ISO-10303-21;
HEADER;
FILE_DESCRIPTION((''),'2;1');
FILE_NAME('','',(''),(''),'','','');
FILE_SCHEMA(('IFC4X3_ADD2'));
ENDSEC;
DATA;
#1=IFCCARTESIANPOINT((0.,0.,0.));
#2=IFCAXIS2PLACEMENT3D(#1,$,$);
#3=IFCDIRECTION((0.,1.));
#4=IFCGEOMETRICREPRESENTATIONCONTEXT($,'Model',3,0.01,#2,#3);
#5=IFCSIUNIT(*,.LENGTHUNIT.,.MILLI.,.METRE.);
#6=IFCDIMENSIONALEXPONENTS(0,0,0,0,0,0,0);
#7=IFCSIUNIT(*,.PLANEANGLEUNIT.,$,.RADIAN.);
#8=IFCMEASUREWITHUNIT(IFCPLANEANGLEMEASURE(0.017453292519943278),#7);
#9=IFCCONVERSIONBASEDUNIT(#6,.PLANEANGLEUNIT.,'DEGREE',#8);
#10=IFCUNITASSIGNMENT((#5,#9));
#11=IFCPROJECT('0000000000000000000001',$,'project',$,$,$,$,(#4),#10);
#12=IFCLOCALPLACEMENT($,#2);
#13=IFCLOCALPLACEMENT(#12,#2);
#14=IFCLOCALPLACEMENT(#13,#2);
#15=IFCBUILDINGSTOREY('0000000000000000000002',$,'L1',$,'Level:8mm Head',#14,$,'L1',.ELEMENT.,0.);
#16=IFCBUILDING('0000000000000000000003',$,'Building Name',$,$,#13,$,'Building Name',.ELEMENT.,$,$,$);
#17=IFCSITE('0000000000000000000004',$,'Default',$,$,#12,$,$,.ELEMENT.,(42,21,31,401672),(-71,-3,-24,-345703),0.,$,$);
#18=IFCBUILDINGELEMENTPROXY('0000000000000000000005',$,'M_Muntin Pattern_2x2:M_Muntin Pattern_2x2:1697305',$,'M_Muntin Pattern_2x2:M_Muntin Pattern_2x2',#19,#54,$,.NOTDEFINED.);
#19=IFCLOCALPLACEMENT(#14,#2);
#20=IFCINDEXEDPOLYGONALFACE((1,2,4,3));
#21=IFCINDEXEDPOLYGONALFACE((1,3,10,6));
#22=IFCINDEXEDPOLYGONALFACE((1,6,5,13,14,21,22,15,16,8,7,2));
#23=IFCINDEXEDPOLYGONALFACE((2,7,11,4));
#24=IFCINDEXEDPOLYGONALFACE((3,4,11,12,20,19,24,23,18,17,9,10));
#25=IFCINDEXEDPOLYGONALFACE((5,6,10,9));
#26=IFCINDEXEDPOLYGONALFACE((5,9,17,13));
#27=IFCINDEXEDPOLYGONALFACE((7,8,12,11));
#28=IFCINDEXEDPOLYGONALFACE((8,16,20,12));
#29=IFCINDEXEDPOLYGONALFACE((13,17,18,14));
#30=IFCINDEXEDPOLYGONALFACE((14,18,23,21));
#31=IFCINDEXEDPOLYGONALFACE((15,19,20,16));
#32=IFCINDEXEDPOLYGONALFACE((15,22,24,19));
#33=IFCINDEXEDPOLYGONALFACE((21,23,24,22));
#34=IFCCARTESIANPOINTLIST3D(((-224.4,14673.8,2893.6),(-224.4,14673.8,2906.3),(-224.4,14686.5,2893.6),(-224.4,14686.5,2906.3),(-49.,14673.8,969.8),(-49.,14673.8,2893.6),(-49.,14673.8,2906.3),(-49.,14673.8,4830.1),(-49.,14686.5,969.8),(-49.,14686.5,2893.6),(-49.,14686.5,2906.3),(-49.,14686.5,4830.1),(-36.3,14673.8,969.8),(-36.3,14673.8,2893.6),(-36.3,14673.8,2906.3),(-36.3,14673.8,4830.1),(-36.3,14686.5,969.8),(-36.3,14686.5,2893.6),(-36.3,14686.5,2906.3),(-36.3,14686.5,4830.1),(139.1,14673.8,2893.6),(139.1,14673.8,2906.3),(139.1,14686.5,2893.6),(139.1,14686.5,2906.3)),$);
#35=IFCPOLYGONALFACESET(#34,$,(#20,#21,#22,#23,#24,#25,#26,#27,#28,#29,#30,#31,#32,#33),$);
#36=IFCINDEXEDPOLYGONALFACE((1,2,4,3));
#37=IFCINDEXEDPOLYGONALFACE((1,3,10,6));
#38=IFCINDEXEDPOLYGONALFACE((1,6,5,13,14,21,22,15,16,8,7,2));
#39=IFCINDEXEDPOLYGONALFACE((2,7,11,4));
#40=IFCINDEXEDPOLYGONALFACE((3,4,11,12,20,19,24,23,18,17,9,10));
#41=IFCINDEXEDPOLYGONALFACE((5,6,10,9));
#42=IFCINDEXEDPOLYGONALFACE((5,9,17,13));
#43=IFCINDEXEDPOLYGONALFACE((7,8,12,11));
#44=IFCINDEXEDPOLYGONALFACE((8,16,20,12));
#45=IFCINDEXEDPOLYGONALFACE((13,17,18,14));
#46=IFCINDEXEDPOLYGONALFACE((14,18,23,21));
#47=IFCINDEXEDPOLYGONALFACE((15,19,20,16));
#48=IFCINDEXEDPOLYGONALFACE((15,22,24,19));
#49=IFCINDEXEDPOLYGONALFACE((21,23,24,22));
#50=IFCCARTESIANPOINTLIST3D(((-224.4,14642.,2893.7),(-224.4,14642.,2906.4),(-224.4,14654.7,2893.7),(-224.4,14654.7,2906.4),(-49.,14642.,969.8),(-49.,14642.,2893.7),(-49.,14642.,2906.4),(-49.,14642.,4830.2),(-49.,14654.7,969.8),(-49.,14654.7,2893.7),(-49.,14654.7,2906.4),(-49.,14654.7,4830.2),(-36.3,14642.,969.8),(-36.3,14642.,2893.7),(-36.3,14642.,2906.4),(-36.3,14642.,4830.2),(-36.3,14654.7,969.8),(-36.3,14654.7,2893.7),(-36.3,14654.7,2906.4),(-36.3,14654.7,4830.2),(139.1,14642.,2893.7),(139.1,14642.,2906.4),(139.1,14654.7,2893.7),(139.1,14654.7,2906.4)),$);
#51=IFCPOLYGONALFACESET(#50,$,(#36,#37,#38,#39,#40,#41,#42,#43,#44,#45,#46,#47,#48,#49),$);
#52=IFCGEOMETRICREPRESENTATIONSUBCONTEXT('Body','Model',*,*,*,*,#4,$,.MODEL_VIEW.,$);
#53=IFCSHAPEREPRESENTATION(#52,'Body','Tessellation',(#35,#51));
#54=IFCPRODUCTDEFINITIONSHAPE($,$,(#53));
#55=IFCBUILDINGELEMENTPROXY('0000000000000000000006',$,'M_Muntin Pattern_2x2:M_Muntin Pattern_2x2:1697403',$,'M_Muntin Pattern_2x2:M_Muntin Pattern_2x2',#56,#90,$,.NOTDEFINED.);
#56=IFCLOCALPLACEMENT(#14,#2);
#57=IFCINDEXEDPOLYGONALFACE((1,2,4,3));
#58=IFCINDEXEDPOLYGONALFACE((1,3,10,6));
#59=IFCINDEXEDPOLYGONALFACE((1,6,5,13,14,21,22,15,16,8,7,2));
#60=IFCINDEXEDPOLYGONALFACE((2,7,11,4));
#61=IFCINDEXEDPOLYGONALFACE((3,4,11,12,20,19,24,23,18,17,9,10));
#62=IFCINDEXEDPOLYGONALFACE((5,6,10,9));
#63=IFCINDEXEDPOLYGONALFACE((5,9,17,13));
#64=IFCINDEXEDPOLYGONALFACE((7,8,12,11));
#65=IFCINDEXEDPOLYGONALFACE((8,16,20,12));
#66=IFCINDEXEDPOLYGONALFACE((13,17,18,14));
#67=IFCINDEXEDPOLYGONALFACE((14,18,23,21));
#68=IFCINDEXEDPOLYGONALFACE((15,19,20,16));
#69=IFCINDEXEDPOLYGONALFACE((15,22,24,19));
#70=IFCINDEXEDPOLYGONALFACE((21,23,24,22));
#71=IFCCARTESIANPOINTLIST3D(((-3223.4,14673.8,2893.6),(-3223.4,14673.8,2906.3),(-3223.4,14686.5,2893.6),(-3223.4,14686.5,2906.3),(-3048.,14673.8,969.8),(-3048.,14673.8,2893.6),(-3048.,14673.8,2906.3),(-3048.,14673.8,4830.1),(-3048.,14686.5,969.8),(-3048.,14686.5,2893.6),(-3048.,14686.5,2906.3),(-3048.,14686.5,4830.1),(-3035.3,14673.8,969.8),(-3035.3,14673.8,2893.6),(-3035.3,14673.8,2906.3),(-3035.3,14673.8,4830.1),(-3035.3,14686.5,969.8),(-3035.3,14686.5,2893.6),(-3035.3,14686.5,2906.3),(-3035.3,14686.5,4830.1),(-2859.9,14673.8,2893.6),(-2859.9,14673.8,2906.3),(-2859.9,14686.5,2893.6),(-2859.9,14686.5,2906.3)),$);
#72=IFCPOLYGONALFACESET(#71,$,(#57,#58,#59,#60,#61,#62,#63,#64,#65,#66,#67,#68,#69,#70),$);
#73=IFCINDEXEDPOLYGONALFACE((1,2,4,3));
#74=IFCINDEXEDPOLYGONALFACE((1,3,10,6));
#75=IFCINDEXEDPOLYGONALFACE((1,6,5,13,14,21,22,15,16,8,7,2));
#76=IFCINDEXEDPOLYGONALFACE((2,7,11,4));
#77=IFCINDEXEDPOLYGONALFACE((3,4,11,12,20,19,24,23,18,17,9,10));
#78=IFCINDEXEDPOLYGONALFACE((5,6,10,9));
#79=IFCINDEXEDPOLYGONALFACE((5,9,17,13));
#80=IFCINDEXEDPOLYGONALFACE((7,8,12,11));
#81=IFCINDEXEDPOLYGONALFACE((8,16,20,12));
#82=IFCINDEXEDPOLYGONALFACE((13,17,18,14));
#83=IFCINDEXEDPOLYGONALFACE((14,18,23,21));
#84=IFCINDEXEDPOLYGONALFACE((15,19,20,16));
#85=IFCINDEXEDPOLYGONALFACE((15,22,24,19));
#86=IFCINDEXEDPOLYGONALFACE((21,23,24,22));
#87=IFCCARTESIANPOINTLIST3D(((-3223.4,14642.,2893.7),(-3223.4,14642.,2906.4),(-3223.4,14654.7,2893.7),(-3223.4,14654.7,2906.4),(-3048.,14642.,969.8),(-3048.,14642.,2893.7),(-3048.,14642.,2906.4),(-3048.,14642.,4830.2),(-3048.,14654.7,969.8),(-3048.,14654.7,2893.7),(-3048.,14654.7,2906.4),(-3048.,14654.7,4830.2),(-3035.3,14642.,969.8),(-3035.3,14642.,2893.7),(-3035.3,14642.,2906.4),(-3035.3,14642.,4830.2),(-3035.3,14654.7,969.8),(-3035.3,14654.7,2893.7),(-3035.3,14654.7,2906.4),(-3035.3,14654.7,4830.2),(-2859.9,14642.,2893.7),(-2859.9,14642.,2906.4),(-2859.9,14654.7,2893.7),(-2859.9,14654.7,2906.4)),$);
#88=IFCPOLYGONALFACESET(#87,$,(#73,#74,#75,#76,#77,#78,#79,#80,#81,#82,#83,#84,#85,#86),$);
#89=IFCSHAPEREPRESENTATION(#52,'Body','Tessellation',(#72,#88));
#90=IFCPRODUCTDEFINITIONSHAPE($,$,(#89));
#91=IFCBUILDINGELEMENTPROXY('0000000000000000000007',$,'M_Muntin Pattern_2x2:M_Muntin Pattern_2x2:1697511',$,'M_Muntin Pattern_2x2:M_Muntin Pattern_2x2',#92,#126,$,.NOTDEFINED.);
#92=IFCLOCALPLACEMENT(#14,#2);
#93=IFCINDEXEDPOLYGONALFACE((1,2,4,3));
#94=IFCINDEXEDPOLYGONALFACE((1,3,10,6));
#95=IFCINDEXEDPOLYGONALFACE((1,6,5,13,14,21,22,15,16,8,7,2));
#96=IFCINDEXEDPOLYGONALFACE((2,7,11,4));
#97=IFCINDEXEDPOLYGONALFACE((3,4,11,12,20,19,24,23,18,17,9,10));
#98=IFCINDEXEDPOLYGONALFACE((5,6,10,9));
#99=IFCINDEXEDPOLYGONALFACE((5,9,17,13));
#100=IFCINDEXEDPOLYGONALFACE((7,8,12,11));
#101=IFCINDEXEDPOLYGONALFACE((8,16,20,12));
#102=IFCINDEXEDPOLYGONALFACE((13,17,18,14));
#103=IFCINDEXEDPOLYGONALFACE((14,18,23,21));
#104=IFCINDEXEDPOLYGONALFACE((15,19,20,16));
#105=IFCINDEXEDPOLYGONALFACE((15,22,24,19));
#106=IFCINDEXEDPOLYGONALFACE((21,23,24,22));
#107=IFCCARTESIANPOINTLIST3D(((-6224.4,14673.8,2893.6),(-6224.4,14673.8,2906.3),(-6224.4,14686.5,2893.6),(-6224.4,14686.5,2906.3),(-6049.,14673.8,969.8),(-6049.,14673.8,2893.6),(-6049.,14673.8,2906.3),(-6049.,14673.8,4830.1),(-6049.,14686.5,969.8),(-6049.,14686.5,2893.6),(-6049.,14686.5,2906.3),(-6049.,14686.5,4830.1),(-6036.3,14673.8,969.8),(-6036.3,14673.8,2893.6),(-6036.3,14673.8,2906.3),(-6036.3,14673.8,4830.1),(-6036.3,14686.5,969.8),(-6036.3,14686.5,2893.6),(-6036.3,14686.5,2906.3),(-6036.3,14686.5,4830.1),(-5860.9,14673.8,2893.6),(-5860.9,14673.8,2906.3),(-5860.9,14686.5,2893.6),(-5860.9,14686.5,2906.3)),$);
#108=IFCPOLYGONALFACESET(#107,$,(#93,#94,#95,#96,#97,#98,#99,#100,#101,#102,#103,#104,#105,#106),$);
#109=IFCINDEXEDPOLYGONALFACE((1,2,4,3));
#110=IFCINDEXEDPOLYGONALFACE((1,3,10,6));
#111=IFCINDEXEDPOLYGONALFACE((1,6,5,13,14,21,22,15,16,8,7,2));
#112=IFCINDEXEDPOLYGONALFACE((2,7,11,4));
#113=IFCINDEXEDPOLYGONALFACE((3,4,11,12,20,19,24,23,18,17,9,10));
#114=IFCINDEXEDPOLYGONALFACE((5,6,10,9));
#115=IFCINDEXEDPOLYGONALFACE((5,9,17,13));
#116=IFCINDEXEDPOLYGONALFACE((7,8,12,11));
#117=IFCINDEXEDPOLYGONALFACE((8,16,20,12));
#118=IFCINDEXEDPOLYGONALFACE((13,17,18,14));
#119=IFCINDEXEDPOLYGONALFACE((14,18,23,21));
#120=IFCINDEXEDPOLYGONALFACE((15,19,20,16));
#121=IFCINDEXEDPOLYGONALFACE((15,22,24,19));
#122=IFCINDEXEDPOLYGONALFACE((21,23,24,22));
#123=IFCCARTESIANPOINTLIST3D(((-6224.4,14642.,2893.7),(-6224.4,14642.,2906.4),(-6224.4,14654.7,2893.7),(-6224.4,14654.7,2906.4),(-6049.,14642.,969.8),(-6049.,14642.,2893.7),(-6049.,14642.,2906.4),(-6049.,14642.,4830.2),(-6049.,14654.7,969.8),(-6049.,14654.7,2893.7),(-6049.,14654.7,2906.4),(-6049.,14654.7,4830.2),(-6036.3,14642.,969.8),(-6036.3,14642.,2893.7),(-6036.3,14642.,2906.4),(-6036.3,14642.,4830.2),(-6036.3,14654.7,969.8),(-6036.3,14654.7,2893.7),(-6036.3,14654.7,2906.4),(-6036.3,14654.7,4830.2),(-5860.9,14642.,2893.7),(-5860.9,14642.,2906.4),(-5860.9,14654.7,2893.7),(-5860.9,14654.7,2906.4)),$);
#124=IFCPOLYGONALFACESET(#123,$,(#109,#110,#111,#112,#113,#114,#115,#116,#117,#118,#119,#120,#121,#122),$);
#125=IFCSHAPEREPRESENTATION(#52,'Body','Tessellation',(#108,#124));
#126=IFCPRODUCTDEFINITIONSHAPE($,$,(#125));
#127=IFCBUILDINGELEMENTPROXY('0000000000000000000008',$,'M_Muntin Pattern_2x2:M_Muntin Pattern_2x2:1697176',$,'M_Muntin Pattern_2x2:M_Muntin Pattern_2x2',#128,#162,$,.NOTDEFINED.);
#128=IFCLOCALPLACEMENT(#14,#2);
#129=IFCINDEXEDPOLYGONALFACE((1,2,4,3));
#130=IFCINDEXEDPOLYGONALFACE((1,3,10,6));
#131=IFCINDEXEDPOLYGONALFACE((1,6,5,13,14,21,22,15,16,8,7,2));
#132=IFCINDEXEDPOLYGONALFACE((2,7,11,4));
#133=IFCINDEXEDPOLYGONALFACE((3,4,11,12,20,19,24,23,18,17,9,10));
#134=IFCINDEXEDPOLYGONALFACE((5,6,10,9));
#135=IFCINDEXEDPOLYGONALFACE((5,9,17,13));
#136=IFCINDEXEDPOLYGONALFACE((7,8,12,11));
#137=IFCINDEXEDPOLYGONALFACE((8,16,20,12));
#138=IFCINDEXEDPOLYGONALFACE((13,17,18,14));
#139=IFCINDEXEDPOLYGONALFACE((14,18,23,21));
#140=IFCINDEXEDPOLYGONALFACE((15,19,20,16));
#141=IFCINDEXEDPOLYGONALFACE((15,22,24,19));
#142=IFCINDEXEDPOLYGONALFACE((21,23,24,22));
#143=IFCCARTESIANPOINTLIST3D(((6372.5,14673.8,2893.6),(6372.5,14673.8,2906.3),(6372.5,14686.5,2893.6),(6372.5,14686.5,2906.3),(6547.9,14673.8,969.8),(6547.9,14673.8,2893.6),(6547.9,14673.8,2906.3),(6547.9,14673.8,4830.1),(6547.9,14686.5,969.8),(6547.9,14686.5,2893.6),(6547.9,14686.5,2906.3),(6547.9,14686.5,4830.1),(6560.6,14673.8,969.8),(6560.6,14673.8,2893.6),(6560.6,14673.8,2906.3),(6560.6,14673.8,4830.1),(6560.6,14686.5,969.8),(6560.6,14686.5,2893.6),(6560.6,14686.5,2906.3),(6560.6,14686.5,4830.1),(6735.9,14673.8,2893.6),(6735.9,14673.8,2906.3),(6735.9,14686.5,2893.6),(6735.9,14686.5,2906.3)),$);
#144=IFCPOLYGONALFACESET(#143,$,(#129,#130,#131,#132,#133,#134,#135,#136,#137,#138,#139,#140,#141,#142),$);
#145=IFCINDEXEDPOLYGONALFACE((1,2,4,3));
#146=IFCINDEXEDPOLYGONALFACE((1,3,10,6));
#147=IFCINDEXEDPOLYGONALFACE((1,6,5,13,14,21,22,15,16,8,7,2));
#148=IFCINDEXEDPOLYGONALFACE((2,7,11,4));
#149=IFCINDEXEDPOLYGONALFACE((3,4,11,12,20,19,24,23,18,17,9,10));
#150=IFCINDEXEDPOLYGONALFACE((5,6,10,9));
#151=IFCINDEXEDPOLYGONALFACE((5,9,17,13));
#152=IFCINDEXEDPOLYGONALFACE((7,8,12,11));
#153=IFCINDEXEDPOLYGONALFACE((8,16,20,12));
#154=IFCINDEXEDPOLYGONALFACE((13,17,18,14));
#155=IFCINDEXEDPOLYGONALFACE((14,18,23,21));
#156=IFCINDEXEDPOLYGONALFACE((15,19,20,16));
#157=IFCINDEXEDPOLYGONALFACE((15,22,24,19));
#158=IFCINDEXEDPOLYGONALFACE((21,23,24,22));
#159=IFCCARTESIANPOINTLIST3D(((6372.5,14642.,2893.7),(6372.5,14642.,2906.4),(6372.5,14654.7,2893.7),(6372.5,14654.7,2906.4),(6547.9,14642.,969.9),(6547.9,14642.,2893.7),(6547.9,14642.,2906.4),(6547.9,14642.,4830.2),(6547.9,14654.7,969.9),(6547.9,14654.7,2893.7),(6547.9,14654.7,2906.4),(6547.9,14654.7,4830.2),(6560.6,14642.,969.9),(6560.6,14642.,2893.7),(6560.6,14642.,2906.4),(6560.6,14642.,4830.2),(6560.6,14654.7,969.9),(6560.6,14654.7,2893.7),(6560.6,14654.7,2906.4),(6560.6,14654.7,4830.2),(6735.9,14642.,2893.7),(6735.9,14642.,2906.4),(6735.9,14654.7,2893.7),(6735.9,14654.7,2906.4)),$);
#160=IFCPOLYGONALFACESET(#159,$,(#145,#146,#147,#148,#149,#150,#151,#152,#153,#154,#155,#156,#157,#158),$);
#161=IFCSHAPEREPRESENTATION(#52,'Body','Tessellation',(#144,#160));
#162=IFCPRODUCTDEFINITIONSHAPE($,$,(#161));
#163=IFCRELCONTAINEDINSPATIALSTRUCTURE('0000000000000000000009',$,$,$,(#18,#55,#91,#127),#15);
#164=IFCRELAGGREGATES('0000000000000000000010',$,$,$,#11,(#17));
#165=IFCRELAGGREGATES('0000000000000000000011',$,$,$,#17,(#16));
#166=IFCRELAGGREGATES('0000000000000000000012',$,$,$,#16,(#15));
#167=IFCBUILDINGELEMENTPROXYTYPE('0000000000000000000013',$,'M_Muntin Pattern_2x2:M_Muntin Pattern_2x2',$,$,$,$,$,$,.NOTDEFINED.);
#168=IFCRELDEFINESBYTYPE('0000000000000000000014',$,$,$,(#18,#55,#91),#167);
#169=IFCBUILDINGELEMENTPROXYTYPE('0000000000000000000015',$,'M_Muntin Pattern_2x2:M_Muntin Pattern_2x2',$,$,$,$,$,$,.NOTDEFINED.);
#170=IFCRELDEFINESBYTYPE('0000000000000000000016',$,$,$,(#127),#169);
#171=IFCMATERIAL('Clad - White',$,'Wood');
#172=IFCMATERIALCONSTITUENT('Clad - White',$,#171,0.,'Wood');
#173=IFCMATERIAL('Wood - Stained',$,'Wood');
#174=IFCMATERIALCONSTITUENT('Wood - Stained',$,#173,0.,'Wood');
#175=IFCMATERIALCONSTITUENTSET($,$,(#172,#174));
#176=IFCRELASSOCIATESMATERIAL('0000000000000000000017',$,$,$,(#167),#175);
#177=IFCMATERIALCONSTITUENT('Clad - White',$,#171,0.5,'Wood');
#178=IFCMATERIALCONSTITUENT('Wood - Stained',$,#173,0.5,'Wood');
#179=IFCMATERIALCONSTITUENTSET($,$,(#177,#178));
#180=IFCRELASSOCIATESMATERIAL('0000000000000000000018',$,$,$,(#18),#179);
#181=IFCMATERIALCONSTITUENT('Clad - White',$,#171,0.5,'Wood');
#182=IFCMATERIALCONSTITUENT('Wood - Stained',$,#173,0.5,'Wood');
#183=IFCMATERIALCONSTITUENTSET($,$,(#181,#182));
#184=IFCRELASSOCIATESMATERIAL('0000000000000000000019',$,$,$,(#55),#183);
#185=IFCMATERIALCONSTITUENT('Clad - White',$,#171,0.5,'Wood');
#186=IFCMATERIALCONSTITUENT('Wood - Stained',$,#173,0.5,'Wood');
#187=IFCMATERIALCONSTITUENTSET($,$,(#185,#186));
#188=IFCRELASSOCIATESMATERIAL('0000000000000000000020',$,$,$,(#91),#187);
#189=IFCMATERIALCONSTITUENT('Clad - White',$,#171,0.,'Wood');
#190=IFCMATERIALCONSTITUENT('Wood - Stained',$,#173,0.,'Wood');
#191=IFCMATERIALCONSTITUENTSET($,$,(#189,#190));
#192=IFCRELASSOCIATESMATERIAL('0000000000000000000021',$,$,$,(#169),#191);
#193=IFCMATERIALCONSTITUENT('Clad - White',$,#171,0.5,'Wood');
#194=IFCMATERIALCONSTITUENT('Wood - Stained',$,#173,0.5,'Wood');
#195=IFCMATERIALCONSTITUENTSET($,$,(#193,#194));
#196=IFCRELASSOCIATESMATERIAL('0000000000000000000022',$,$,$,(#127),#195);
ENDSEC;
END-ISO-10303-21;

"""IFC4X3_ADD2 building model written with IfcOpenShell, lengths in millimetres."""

from ifc_helpers import new_model, entity, si_unit, converted_unit, direction, frame, origin, place, context, subcontext, project, spatial, polyline, outline, extrude, source, transform, mapped, material, constituent, constituent_set, type_object, type_shapes, element, save


model = new_model("IFC4X3_ADD2")

# Units and contexts
model_context = context("Model", 3, precision=0.01, world=origin(), true_north=direction((0.0, 1.0)))
body_context = subcontext(model_context, "Body", "Model", "MODEL_VIEW")
ifc_project = project(units=[si_unit("LENGTHUNIT", "METRE", prefix="MILLI"), converted_unit("PLANEANGLEUNIT", "DEGREE", entity("IfcPlaneAngleMeasure", 0.017453292519943278), si_unit("PLANEANGLEUNIT", "RADIAN"), dimensions=[0, 0, 0, 0, 0, 0, 0])], contexts=[model_context])

# Site, building, storey
site_placement = place(None, origin())
site = spatial("IfcSite", under=ifc_project, at=site_placement, Name="Default", CompositionType="ELEMENT", RefLatitude=(42, 21, 31, 401672), RefLongitude=(-71, -3, -24, -345703), RefElevation=0.0)
building_placement = place(site_placement, origin())
building = spatial("IfcBuilding", under=site, at=building_placement, Name="Building Name", LongName="Building Name", CompositionType="ELEMENT")
storey_placement = place(building_placement, origin())
storey = spatial("IfcBuildingStorey", under=building, at=storey_placement, Name="L1", ObjectType="Level:8mm Head", LongName="L1", CompositionType="ELEMENT", Elevation=0.0)

# Building element proxies
ifc_material_1 = material(Name="Clad - White", Category="Wood")
ifc_material_2 = material(Name="Wood - Stained", Category="Wood")
ifc_constituent_1 = constituent(ifc_material_1, Name="Clad - White", Category="Wood", fraction=0.0)
ifc_constituent_2 = constituent(ifc_material_2, Name="Wood - Stained", Category="Wood", fraction=0.0)
ifc_constituent_set_1 = constituent_set(constituents=[ifc_constituent_1, ifc_constituent_2])
building_element_proxy_type_1 = type_object("IfcBuildingElementProxyType", Name="M_Muntin Pattern_2x2:M_Muntin Pattern_2x2", PredefinedType="NOTDEFINED", material=ifc_constituent_set_1)
shared_shape_1 = source(origin(), body_context, "Body", "SweptSolid", [
    extrude(outline(polyline([(6.4, -6.4), (1930.1, -6.4), (1930.1, 6.3), (6.4, 6.3), (6.4, 181.7), (-6.3, 181.7), (-6.3, 6.3), (-1930.2, 6.3), (-1930.2, -6.4), (-6.3, -6.4), (-6.3, -181.7), (6.4, -181.7), (6.4, -6.4)])), frame((0.0, 9.5, 1930.1), z_axis=(0.0, 1.0, 0.0), x_axis=(0.0, 0.0, 1.0)), (0.0, 0.0, 1.0), 12.7),
    extrude(outline(polyline([(6.4, -6.4), (1930.2, -6.4), (1930.2, 6.3), (6.4, 6.3), (6.4, 181.7), (-6.3, 181.7), (-6.3, 6.3), (-1930.2, 6.3), (-1930.2, -6.4), (-6.3, -6.4), (-6.3, -181.7), (6.4, -181.7), (6.4, -6.4)])), frame((0.0, -22.2, 1930.2), z_axis=(0.0, 1.0, 0.0), x_axis=(0.0, 0.0, 1.0)), (0.0, 0.0, 1.0), 12.7),
])
type_shapes(building_element_proxy_type_1, [shared_shape_1])
ifc_constituent_3 = constituent(ifc_material_1, Name="Clad - White", Category="Wood", fraction=0.5)
ifc_constituent_4 = constituent(ifc_material_2, Name="Wood - Stained", Category="Wood", fraction=0.5)
ifc_constituent_set_2 = constituent_set(constituents=[ifc_constituent_3, ifc_constituent_4])
proxy_1_placement = place(storey_placement, frame((-42.6, 14664.3, 969.8)))
element("IfcBuildingElementProxy", 1, at=proxy_1_placement, inside=storey, type_object=building_element_proxy_type_1, material=ifc_constituent_set_2, Name="M_Muntin Pattern_2x2:M_Muntin Pattern_2x2:1697305", ObjectType="M_Muntin Pattern_2x2:M_Muntin Pattern_2x2", PredefinedType="NOTDEFINED", context=body_context, shape_type="MappedRepresentation", body=[
    mapped(shared_shape_1, transform((0.0, 0.0, 0.0), scale=1.0)),
])
ifc_constituent_5 = constituent(ifc_material_1, Name="Clad - White", Category="Wood", fraction=0.5)
ifc_constituent_6 = constituent(ifc_material_2, Name="Wood - Stained", Category="Wood", fraction=0.5)
ifc_constituent_set_3 = constituent_set(constituents=[ifc_constituent_5, ifc_constituent_6])
proxy_2_placement = place(storey_placement, frame((-3041.6, 14664.3, 969.8)))
element("IfcBuildingElementProxy", 2, at=proxy_2_placement, inside=storey, type_object=building_element_proxy_type_1, material=ifc_constituent_set_3, Name="M_Muntin Pattern_2x2:M_Muntin Pattern_2x2:1697403", ObjectType="M_Muntin Pattern_2x2:M_Muntin Pattern_2x2", PredefinedType="NOTDEFINED", context=body_context, shape_type="MappedRepresentation", body=[
    mapped(shared_shape_1, transform((0.0, 0.0, 0.0), scale=1.0)),
])
ifc_constituent_7 = constituent(ifc_material_1, Name="Clad - White", Category="Wood", fraction=0.5)
ifc_constituent_8 = constituent(ifc_material_2, Name="Wood - Stained", Category="Wood", fraction=0.5)
ifc_constituent_set_4 = constituent_set(constituents=[ifc_constituent_7, ifc_constituent_8])
proxy_3_placement = place(storey_placement, frame((-6042.6, 14664.3, 969.8)))
element("IfcBuildingElementProxy", 3, at=proxy_3_placement, inside=storey, type_object=building_element_proxy_type_1, material=ifc_constituent_set_4, Name="M_Muntin Pattern_2x2:M_Muntin Pattern_2x2:1697511", ObjectType="M_Muntin Pattern_2x2:M_Muntin Pattern_2x2", PredefinedType="NOTDEFINED", context=body_context, shape_type="MappedRepresentation", body=[
    mapped(shared_shape_1, transform((0.0, 0.0, 0.0), scale=1.0)),
])
ifc_constituent_9 = constituent(ifc_material_1, Name="Clad - White", Category="Wood", fraction=0.5)
ifc_constituent_10 = constituent(ifc_material_2, Name="Wood - Stained", Category="Wood", fraction=0.5)
ifc_constituent_set_5 = constituent_set(constituents=[ifc_constituent_9, ifc_constituent_10])
ifc_constituent_11 = constituent(ifc_material_1, Name="Clad - White", Category="Wood", fraction=0.0)
ifc_constituent_12 = constituent(ifc_material_2, Name="Wood - Stained", Category="Wood", fraction=0.0)
ifc_constituent_set_6 = constituent_set(constituents=[ifc_constituent_11, ifc_constituent_12])
building_element_proxy_type_2 = type_object("IfcBuildingElementProxyType", Name="M_Muntin Pattern_2x2:M_Muntin Pattern_2x2", PredefinedType="NOTDEFINED", material=ifc_constituent_set_6)
shared_shape_2 = source(origin(), body_context, "Body", "SweptSolid", [
    extrude(outline(polyline([(6.4, -6.4), (1930.1, -6.4), (1930.1, 6.3), (6.4, 6.3), (6.4, 181.7), (-6.3, 181.7), (-6.3, 6.3), (-1930.2, 6.3), (-1930.2, -6.4), (-6.3, -6.4), (-6.3, -181.7), (6.4, -181.7), (6.4, -6.4)])), frame((0.0, -22.2, 1930.1), z_axis=(0.0, 1.0, 0.0), x_axis=(0.0, 0.0, 1.0)), (0.0, 0.0, 1.0), 12.7),
    extrude(outline(polyline([(6.4, -6.4), (1930.2, -6.4), (1930.2, 6.3), (6.4, 6.3), (6.4, 181.7), (-6.3, 181.7), (-6.3, 6.3), (-1930.2, 6.3), (-1930.2, -6.4), (-6.3, -6.4), (-6.3, -181.7), (6.4, -181.7), (6.4, -6.4)])), frame((0.0, 9.5, 1930.2), z_axis=(0.0, 1.0, 0.0), x_axis=(0.0, 0.0, 1.0)), (0.0, 0.0, 1.0), 12.7),
])
type_shapes(building_element_proxy_type_2, [shared_shape_2])
proxy_4_placement = place(storey_placement, frame((6554.2, 14664.3, 969.9), z_axis=(0.0, 0.0, 1.0), x_axis=(-1.0, 0.0, 0.0)))
element("IfcBuildingElementProxy", 4, at=proxy_4_placement, inside=storey, type_object=building_element_proxy_type_2, material=ifc_constituent_set_5, Name="M_Muntin Pattern_2x2:M_Muntin Pattern_2x2:1697176", ObjectType="M_Muntin Pattern_2x2:M_Muntin Pattern_2x2", PredefinedType="NOTDEFINED", context=body_context, shape_type="MappedRepresentation", body=[
    mapped(shared_shape_2, transform((0.0, 0.0, 0.0), scale=1.0)),
])

save(model, "model.ifc")
